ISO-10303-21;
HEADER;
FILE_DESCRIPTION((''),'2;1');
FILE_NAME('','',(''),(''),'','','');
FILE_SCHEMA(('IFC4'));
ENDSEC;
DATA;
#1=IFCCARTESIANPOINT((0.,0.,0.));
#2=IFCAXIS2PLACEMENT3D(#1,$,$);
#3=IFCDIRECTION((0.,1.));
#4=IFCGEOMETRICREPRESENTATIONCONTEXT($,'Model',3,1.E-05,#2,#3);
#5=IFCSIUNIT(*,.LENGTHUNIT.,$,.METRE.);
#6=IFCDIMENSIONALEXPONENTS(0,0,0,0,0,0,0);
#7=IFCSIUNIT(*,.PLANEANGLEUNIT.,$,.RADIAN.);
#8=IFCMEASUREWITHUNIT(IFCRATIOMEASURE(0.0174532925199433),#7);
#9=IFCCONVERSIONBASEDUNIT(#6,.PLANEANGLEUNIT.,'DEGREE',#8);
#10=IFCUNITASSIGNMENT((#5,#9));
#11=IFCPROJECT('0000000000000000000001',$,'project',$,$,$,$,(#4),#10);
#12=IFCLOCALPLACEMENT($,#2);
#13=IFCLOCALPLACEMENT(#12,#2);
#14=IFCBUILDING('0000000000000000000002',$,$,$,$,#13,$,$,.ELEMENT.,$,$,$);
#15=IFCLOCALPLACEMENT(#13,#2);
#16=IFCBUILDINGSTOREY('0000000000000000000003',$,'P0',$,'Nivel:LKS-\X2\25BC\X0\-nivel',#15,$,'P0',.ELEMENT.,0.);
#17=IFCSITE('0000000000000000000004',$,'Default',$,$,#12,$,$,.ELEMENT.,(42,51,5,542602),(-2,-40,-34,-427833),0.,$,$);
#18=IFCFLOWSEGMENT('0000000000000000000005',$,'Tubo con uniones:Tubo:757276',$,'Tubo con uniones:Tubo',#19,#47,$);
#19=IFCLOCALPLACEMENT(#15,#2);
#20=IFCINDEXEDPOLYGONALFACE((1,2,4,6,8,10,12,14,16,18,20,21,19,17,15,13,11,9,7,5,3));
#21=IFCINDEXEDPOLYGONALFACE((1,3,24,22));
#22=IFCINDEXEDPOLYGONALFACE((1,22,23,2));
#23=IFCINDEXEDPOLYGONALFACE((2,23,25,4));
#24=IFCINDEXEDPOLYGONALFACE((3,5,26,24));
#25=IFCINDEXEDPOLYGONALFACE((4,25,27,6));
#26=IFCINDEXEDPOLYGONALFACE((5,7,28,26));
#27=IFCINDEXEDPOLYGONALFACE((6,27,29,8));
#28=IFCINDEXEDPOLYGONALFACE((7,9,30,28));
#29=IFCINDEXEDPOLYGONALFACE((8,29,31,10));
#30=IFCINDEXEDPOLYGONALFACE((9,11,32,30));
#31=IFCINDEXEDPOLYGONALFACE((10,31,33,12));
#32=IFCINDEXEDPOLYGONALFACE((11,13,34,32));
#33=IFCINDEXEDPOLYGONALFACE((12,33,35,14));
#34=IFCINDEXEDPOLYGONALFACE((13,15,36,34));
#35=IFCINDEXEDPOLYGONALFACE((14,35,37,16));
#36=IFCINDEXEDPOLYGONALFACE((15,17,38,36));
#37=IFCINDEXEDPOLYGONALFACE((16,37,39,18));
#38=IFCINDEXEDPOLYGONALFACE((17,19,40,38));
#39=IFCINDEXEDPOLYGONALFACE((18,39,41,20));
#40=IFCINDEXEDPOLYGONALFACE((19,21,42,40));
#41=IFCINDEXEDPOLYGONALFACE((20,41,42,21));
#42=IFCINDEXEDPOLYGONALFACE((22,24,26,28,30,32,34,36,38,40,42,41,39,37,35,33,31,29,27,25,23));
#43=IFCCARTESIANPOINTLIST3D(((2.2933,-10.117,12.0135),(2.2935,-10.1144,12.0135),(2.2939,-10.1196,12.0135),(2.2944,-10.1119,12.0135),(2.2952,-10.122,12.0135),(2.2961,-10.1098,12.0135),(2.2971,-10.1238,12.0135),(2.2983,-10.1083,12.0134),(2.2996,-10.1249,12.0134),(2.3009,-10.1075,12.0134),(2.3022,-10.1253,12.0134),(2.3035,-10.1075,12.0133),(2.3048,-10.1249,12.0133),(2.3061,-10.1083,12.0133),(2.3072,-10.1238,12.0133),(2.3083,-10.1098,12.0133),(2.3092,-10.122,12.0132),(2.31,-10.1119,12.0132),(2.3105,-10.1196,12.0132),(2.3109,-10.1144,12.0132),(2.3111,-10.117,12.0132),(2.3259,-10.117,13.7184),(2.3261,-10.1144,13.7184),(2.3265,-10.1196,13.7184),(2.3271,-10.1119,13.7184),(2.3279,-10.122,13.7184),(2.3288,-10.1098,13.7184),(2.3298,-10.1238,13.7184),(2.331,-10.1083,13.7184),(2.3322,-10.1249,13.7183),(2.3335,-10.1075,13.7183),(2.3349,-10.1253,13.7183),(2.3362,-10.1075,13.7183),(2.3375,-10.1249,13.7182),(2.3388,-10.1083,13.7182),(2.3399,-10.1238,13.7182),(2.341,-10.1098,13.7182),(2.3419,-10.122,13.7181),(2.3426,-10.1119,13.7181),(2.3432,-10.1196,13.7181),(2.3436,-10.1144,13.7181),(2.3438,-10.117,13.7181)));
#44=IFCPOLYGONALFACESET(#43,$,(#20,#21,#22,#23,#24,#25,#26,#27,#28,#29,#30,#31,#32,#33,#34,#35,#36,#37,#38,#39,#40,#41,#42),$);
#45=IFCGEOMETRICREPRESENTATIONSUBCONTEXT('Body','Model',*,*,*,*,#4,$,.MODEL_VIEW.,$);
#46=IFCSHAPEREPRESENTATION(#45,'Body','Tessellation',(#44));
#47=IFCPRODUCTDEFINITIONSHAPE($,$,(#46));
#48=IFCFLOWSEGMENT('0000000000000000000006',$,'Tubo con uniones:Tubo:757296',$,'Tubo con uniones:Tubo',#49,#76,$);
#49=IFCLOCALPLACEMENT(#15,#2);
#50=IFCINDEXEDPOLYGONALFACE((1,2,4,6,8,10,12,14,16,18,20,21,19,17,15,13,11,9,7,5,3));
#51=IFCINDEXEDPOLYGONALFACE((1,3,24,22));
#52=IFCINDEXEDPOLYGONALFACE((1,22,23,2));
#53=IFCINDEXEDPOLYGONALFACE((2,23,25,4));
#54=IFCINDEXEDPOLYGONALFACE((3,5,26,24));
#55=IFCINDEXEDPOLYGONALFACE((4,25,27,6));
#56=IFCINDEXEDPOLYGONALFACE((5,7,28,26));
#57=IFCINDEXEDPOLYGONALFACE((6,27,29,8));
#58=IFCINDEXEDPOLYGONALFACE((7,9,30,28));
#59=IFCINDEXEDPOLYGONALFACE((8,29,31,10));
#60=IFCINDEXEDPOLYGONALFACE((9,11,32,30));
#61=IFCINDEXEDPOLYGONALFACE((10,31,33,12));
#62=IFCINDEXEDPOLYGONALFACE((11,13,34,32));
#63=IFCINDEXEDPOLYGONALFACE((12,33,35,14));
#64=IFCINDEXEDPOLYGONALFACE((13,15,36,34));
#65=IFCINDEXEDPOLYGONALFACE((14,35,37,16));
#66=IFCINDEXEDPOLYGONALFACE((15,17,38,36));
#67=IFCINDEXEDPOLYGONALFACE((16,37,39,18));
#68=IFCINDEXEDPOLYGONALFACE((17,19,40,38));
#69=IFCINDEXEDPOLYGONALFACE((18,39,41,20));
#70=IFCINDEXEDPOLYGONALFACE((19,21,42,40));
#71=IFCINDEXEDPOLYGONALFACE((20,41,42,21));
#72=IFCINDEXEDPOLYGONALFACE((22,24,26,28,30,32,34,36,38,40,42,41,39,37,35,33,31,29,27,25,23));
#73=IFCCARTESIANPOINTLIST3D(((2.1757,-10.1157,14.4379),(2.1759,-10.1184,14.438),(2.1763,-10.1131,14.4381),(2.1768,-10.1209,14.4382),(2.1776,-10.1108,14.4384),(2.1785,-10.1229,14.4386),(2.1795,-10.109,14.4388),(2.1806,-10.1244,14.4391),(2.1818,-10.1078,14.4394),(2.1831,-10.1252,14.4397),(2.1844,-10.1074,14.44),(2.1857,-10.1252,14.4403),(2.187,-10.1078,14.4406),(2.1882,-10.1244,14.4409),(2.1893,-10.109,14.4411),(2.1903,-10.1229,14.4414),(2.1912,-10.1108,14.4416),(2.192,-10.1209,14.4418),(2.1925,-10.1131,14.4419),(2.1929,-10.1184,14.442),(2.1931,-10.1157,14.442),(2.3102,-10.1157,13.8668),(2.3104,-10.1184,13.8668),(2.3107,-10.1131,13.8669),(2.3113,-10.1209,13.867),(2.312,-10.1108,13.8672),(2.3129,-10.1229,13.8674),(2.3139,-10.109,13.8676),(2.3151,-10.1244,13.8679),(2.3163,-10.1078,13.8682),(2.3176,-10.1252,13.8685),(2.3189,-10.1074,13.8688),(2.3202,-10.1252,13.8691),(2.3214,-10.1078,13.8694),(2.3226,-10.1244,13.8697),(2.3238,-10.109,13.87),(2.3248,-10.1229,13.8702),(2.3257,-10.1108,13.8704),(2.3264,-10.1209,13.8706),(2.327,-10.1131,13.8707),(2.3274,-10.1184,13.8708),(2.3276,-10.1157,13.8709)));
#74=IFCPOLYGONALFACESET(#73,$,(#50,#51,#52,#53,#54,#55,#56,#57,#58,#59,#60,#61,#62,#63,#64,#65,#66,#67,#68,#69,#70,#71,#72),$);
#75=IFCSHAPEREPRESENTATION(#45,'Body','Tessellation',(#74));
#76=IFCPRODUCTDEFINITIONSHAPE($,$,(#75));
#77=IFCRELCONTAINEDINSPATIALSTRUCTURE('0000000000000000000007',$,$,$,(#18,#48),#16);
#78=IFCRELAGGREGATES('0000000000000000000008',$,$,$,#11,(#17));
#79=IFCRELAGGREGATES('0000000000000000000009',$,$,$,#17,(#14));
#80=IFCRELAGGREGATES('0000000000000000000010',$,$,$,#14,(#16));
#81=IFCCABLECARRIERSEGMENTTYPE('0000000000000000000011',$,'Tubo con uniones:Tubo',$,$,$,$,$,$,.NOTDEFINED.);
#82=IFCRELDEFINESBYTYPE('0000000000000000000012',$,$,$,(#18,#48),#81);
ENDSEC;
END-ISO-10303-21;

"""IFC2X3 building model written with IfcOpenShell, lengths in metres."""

from ifc_helpers import new_model, entity, si_unit, converted_unit, direction, frame, frame_2d, origin, origin_2d_with_axis, place, context, subcontext, project, spatial, circle, extrude, type_object, element, save


model = new_model("IFC2X3")

# Units and contexts
model_context = context("Model", 3, precision=1e-05, world=origin(), true_north=direction((0.0, 1.0)))
body_context = subcontext(model_context, "Body", "Model", "MODEL_VIEW")
ifc_project = project(units=[si_unit("LENGTHUNIT", "METRE"), converted_unit("PLANEANGLEUNIT", "DEGREE", entity("IfcRatioMeasure", 0.0174532925199433), si_unit("PLANEANGLEUNIT", "RADIAN"), dimensions=[0, 0, 0, 0, 0, 0, 0])], contexts=[model_context])

# Site, building, storey
site_placement = place(None, origin())
site = spatial("IfcSite", under=ifc_project, at=site_placement, Name="Default", CompositionType="ELEMENT", RefLatitude=(42, 51, 5, 542602), RefLongitude=(-2, -40, -34, -427833), RefElevation=0.0)
building_placement = place(site_placement, origin())
building = spatial("IfcBuilding", under=site, at=building_placement, CompositionType="ELEMENT")
storey_placement = place(building_placement, origin())
storey = spatial("IfcBuildingStorey", under=building, at=storey_placement, Name="P0", ObjectType="Nivel:LKS-▼-nivel", LongName="P0", CompositionType="ELEMENT", Elevation=0.0)

# Flow segments
cable_carrier_segment_type = type_object("IfcCableCarrierSegmentType", Name="Tubo con uniones:Tubo", PredefinedType="NOTDEFINED")
flow_segment_1_placement = place(storey_placement, origin())
element("IfcFlowSegment", 1, at=flow_segment_1_placement, inside=storey, type_object=cable_carrier_segment_type, Name="Tubo con uniones:Tubo:757276", ObjectType="Tubo con uniones:Tubo", context=body_context, shape_type="SweptSolid", body=[
    extrude(circle(Radius=0.009, at=origin_2d_with_axis()), frame((2.3022, -10.1164, 12.0134), z_axis=(0.019165, 0.0, 0.999816), x_axis=(0.0, -1.0, 0.0)), (0.0, 0.0, 1.0), 1.7052),
])
flow_segment_2_placement = place(storey_placement, origin())
element("IfcFlowSegment", 2, at=flow_segment_2_placement, inside=storey, type_object=cable_carrier_segment_type, Name="Tubo con uniones:Tubo:757296", ObjectType="Tubo con uniones:Tubo", context=body_context, shape_type="SweptSolid", body=[
    extrude(circle(Radius=0.009, at=frame_2d((0.0, 0.0), x_axis=(1.0, 0.0))), frame((2.1844, -10.1164, 14.44), z_axis=(0.229155, 0.0, -0.97339), x_axis=(0.0, 1.0, 0.0)), (0.0, 0.0, 1.0), 0.5868),
])

save(model, "model.ifc")
